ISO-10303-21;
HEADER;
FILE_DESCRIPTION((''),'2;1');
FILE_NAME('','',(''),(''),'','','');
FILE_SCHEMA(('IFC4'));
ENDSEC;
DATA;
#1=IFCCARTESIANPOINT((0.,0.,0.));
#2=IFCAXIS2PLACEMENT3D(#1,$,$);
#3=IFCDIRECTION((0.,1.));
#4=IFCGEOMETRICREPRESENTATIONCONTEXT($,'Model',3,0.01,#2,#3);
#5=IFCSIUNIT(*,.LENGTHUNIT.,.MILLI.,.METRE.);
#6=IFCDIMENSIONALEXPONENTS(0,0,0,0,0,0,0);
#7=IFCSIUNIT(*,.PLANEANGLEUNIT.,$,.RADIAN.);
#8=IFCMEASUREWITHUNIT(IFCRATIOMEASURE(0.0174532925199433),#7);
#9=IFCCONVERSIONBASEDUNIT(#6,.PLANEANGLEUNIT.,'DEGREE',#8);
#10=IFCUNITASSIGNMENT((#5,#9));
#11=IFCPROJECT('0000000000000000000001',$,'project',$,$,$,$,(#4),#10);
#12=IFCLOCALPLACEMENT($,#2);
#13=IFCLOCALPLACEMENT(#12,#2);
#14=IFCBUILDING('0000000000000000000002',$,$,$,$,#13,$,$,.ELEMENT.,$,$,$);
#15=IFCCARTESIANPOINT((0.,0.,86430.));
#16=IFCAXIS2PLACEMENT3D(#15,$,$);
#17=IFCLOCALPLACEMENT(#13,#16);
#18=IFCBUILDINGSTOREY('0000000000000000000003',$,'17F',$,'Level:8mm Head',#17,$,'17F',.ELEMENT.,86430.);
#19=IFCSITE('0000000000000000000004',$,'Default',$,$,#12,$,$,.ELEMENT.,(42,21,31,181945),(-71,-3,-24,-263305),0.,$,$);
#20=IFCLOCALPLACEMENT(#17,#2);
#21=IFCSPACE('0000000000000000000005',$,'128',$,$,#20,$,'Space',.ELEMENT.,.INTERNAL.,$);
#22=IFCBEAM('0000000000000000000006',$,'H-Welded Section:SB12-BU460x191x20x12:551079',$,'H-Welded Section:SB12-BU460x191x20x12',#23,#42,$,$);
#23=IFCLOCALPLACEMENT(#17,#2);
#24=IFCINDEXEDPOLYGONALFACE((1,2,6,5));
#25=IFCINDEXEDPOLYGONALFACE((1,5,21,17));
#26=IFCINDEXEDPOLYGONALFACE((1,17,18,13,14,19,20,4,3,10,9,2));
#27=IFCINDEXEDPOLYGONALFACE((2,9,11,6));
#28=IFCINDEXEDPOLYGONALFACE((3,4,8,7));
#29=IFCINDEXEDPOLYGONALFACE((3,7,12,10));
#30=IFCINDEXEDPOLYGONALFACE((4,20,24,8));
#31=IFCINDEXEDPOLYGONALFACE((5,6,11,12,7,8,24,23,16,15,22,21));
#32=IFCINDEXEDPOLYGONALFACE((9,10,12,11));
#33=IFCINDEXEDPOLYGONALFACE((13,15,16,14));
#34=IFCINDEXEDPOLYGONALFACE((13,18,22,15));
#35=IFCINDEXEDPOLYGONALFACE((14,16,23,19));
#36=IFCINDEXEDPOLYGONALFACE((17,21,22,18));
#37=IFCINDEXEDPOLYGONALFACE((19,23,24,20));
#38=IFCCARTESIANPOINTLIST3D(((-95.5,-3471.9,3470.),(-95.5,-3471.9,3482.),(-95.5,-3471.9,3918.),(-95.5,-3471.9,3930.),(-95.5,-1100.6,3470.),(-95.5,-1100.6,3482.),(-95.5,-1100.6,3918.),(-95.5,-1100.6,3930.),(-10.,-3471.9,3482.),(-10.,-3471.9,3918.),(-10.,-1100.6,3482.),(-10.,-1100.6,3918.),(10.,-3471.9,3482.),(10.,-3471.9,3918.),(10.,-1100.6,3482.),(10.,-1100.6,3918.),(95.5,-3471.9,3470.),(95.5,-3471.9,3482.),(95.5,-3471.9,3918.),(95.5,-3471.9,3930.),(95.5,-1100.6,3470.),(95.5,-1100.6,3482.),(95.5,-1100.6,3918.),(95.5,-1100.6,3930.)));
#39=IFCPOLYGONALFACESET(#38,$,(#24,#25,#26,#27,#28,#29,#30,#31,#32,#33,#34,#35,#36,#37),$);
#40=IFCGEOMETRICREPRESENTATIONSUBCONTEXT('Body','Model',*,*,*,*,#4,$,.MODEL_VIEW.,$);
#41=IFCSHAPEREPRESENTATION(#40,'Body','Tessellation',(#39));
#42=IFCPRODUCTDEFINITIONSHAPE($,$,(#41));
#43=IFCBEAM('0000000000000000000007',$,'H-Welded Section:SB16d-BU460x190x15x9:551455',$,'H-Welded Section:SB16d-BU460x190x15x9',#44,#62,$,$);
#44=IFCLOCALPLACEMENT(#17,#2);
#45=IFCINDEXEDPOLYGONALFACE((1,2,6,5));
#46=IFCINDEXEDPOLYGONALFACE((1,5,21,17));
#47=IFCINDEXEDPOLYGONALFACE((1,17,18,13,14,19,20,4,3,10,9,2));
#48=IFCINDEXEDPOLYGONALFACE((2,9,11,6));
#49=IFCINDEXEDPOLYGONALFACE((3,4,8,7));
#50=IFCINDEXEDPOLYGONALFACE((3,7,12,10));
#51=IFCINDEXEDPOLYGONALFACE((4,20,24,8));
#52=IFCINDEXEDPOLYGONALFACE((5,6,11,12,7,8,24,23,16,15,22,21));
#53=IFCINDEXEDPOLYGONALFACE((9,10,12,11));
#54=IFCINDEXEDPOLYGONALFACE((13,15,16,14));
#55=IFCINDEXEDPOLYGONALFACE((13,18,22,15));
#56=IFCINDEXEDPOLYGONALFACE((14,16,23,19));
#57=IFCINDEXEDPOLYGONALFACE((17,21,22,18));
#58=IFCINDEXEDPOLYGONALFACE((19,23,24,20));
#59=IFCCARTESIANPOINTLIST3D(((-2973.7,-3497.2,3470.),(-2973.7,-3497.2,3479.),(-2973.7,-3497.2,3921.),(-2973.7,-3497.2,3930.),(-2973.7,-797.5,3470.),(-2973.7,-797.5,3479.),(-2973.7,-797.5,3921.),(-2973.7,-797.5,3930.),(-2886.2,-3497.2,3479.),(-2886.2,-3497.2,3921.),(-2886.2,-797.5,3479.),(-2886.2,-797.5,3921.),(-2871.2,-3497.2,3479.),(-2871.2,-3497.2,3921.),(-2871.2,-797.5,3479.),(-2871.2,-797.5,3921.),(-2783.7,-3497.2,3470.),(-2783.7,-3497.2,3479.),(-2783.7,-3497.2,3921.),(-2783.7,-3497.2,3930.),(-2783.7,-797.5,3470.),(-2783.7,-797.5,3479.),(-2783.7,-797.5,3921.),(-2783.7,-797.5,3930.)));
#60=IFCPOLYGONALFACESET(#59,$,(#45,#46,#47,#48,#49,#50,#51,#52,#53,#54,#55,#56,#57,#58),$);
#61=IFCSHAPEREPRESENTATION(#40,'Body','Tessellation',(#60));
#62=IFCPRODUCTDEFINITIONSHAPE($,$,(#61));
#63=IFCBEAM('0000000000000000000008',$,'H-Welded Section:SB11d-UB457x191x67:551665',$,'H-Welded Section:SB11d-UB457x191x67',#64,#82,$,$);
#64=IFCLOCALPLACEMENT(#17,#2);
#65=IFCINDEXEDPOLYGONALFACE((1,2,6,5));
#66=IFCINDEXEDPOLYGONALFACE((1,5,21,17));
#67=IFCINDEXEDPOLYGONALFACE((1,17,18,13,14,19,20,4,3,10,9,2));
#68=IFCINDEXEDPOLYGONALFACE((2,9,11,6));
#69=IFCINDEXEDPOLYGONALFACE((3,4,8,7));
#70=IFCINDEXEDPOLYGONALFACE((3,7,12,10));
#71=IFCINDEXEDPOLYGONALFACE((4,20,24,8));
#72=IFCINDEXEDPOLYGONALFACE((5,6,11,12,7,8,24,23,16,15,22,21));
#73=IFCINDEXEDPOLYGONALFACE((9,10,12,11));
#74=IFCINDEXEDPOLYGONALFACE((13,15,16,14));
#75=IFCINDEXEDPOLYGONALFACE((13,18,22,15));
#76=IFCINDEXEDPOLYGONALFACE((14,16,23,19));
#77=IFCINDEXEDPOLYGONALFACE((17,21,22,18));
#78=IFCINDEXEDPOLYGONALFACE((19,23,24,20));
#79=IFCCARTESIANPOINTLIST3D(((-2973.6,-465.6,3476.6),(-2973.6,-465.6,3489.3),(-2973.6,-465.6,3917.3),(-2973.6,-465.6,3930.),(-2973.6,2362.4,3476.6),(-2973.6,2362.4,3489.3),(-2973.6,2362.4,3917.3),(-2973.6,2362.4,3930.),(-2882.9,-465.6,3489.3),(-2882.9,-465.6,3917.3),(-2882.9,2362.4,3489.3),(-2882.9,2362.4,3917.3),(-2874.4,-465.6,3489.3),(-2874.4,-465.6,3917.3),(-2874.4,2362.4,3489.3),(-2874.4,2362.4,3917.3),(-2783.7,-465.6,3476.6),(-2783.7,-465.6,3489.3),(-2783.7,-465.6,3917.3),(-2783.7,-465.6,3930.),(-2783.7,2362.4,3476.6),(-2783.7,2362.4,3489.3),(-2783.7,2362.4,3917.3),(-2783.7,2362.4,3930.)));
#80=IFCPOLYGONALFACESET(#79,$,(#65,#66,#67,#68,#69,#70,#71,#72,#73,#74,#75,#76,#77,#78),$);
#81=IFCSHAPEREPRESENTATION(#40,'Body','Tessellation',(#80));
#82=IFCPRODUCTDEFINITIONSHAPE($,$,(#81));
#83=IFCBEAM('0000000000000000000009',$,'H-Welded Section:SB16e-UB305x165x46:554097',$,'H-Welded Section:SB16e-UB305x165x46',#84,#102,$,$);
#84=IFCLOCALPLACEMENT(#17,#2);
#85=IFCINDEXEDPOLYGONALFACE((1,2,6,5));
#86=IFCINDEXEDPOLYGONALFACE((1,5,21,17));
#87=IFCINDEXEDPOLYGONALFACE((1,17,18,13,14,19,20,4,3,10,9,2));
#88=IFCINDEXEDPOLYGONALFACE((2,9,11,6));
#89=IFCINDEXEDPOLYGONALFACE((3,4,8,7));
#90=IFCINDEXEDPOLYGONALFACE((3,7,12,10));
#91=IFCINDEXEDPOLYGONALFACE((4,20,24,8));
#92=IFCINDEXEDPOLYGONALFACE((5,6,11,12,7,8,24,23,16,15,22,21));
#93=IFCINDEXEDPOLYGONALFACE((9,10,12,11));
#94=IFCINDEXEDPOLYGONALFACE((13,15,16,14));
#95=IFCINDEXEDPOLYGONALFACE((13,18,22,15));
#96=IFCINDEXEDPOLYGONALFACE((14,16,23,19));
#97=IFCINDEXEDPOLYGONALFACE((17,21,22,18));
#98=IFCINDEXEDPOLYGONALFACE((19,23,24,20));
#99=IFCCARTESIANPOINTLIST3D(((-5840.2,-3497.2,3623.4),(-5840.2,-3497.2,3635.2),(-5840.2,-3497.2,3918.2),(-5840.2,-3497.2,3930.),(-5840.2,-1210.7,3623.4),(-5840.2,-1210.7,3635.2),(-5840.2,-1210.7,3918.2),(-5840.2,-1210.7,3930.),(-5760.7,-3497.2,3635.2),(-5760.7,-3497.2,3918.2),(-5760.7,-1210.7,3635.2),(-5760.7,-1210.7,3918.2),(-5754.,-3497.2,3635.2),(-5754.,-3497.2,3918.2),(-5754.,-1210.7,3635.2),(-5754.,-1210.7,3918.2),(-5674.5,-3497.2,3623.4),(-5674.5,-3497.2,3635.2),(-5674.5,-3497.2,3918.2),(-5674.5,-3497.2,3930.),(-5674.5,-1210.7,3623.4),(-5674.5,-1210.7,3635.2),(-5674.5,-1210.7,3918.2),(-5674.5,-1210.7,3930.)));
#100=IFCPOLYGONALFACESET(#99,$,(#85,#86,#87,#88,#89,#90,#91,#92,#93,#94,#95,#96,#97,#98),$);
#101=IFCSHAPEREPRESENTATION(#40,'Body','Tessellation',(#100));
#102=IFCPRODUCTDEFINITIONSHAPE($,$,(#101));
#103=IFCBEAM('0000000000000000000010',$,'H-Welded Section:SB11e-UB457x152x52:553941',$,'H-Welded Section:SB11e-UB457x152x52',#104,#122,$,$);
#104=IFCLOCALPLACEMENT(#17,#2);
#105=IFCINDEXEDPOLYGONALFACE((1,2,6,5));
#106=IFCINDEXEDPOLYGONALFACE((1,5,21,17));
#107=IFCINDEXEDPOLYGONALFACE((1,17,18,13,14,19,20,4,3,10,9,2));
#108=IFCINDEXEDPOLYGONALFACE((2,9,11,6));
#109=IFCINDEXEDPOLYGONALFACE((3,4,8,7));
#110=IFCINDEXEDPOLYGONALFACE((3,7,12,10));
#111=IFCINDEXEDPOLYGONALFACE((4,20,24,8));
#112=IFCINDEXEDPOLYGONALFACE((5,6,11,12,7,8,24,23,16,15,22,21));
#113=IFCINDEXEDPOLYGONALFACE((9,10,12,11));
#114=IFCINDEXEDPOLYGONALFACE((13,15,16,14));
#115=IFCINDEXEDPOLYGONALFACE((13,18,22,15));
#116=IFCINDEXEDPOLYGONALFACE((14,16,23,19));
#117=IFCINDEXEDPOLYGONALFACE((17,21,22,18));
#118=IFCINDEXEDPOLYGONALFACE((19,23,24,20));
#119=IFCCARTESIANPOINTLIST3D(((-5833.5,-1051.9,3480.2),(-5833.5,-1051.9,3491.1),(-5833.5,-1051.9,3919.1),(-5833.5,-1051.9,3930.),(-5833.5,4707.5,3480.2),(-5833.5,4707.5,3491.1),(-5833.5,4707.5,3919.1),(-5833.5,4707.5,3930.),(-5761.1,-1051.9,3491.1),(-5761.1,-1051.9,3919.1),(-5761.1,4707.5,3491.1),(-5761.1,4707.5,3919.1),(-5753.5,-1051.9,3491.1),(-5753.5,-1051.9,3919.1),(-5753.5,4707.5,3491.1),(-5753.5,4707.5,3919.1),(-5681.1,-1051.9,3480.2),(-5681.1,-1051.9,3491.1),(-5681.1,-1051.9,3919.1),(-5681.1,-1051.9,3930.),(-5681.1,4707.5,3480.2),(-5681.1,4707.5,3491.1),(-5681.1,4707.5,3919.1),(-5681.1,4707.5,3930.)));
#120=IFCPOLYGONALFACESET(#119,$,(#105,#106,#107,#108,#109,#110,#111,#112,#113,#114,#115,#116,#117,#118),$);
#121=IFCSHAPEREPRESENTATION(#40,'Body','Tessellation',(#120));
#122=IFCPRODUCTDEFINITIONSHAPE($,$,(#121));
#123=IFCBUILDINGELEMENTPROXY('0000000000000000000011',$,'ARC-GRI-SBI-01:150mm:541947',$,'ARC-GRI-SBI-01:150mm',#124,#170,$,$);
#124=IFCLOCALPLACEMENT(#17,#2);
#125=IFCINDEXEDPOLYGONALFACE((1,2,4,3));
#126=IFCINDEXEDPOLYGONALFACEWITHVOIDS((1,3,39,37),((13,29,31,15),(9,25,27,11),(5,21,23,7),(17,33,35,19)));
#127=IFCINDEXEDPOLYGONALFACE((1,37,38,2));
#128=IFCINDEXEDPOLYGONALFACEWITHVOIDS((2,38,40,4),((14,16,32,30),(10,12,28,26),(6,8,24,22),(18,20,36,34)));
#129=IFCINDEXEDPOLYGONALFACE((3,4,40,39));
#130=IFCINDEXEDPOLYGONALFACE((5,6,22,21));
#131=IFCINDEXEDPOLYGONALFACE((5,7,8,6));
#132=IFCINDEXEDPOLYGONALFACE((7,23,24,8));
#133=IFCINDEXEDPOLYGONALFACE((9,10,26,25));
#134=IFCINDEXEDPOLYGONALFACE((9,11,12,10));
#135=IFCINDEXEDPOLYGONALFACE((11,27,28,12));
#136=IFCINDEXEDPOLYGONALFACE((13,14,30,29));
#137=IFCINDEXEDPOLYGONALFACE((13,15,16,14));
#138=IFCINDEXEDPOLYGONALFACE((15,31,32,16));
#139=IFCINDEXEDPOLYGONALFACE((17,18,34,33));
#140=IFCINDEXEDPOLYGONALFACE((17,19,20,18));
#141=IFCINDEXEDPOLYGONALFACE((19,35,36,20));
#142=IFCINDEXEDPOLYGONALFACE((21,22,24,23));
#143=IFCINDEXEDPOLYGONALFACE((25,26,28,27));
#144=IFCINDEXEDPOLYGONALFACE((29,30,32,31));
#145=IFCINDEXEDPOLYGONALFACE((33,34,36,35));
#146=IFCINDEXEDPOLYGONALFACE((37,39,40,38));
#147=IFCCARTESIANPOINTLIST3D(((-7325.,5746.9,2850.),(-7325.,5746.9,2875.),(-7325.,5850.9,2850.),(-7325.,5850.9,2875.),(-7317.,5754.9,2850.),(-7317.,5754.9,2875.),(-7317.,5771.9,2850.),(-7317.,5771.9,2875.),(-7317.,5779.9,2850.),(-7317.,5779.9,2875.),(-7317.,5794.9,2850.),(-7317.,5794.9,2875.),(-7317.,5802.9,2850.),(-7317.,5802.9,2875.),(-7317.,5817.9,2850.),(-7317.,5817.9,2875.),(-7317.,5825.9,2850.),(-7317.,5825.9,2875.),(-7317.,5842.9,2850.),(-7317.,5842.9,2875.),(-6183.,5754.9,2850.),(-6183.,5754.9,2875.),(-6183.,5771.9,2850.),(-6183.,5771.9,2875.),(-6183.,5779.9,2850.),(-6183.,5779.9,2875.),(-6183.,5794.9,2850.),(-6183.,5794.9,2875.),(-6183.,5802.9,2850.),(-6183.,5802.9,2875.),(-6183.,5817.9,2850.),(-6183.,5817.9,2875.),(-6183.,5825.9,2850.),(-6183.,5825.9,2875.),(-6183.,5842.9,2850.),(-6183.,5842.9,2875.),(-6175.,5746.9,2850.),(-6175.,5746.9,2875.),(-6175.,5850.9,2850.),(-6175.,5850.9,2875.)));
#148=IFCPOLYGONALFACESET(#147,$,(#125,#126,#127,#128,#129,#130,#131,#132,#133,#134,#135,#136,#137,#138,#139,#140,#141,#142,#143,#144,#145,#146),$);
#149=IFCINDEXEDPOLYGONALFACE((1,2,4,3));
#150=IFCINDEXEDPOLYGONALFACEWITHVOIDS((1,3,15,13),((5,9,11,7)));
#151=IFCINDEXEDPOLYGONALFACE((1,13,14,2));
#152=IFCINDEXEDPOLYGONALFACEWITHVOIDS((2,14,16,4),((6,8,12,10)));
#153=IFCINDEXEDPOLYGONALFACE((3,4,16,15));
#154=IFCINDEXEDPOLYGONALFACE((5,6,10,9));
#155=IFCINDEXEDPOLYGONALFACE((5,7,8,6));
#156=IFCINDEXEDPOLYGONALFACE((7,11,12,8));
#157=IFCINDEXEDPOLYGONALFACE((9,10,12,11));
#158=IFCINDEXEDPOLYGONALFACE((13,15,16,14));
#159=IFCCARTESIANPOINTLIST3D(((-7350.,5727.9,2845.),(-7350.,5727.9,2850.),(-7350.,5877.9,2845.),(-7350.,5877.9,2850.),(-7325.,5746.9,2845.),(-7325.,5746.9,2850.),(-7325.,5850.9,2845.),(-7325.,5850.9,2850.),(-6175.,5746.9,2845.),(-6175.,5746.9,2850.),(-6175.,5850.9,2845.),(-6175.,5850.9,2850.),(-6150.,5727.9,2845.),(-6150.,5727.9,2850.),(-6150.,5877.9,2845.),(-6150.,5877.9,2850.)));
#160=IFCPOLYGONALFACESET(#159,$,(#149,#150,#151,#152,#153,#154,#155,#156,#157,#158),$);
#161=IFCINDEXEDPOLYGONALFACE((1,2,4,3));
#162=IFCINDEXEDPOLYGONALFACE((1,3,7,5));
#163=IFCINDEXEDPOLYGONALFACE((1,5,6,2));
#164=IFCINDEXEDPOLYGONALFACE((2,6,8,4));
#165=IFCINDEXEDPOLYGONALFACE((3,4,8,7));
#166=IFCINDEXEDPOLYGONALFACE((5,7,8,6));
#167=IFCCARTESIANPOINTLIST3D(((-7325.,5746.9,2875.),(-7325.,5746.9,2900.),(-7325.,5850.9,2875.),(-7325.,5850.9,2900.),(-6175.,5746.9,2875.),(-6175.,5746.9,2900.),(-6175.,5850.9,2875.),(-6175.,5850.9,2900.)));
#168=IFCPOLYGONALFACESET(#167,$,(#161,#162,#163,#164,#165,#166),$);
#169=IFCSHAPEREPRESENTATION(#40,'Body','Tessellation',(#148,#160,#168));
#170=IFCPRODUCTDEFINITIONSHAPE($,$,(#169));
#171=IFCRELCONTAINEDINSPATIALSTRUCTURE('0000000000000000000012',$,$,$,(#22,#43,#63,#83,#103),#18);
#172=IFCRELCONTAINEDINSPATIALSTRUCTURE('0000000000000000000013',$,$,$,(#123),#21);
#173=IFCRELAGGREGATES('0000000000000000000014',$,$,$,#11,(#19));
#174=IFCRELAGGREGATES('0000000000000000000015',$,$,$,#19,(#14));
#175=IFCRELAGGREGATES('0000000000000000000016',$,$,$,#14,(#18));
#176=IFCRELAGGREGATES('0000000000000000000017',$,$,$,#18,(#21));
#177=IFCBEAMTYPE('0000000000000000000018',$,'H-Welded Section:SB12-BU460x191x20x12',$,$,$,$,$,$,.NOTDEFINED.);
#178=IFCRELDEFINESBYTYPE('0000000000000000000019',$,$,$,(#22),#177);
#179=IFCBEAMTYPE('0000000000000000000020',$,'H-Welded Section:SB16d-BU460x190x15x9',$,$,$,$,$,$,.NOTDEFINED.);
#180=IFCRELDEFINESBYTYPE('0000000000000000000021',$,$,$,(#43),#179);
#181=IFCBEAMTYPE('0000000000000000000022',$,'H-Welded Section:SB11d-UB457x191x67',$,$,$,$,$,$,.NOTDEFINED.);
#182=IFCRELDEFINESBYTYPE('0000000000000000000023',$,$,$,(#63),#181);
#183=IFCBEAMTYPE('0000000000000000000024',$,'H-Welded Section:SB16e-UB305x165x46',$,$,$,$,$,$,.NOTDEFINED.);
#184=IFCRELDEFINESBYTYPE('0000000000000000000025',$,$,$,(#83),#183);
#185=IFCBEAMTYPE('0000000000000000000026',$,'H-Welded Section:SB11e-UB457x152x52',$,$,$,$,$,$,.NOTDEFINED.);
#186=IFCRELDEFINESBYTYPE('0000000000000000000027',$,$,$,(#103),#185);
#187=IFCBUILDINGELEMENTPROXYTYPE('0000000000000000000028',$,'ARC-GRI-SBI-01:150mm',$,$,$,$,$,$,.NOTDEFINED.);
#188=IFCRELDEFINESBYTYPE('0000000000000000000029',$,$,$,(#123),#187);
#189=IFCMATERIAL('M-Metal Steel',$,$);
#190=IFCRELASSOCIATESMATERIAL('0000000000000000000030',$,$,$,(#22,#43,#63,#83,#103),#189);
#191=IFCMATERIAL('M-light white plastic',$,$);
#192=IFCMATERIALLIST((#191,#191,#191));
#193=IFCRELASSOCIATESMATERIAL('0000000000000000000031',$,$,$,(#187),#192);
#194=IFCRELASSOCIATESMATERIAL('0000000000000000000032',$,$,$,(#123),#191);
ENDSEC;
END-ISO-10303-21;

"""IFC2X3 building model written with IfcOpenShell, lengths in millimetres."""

from ifc_helpers import new_model, entity, si_unit, converted_unit, direction, frame, frame_2d, origin, origin_2d_with_axis, place, context, subcontext, project, spatial, polyline, rectangle, i_section, outline, extrude, source, transform, mapped, material, material_list, type_object, type_shapes, element, save


model = new_model("IFC2X3")

# Units and contexts
model_context = context("Model", 3, precision=0.01, world=origin(), true_north=direction((0.0, 1.0)))
body_context = subcontext(model_context, "Body", "Model", "MODEL_VIEW")
ifc_project = project(units=[si_unit("LENGTHUNIT", "METRE", prefix="MILLI"), converted_unit("PLANEANGLEUNIT", "DEGREE", entity("IfcRatioMeasure", 0.0174532925199433), si_unit("PLANEANGLEUNIT", "RADIAN"), dimensions=[0, 0, 0, 0, 0, 0, 0])], contexts=[model_context])

# Site, building, storey
site_placement = place(None, origin())
site = spatial("IfcSite", under=ifc_project, at=site_placement, Name="Default", CompositionType="ELEMENT", RefLatitude=(42, 21, 31, 181945), RefLongitude=(-71, -3, -24, -263305), RefElevation=0.0)
building_placement = place(site_placement, origin())
building = spatial("IfcBuilding", under=site, at=building_placement, CompositionType="ELEMENT")
storey_placement = place(building_placement, frame((0.0, 0.0, 86430.0)))
storey = spatial("IfcBuildingStorey", under=building, at=storey_placement, Name="17F", ObjectType="Level:8mm Head", LongName="17F", CompositionType="ELEMENT", Elevation=86430.0)

# Beams
ifc_material_1 = material(Name="M-Metal Steel")
beam_type_1 = type_object("IfcBeamType", Name="H-Welded Section:SB12-BU460x191x20x12", PredefinedType="NOTDEFINED")
beam_1_placement = place(storey_placement, frame((0.0, -667.1, 0.0), z_axis=(0.0, 0.0, 1.0), x_axis=(0.0, -1.0, 0.0)))
element("IfcBeam", 1, at=beam_1_placement, inside=storey, type_object=beam_type_1, material=ifc_material_1, Name="H-Welded Section:SB12-BU460x191x20x12:551079", ObjectType="H-Welded Section:SB12-BU460x191x20x12", context=body_context, shape_type="SweptSolid", body=[
    extrude(i_section(OverallWidth=191.0, OverallDepth=460.0, WebThickness=20.0, FlangeThickness=12.0, at=frame_2d((0.0, 0.0), x_axis=(0.0, 1.0))), frame((433.5, 0.0, 3700.0), z_axis=(1.0, 0.0, 0.0), x_axis=(0.0, 0.0, -1.0)), (0.0, 0.0, 1.0), 2371.3),
])
beam_type_2 = type_object("IfcBeamType", Name="H-Welded Section:SB16d-BU460x190x15x9", PredefinedType="NOTDEFINED")
beam_2_placement = place(storey_placement, frame((-2878.7, -4004.7, 0.0), z_axis=(0.0, 0.0, 1.0), x_axis=(0.0, 1.0, 0.0)))
element("IfcBeam", 2, at=beam_2_placement, inside=storey, type_object=beam_type_2, material=ifc_material_1, Name="H-Welded Section:SB16d-BU460x190x15x9:551455", ObjectType="H-Welded Section:SB16d-BU460x190x15x9", context=body_context, shape_type="SweptSolid", body=[
    extrude(i_section(OverallWidth=190.0, OverallDepth=460.0, WebThickness=15.0, FlangeThickness=9.0, at=frame_2d((0.0, 0.0), x_axis=(0.0, 1.0))), frame((507.5, 0.0, 3700.0), z_axis=(1.0, 0.0, 0.0), x_axis=(0.0, 0.0, -1.0)), (0.0, 0.0, 1.0), 2699.7),
])
beam_type_3 = type_object("IfcBeamType", Name="H-Welded Section:SB11d-UB457x191x67", PredefinedType="NOTDEFINED")
beam_3_placement = place(storey_placement, frame((-2878.7, 2476.3, 0.0), z_axis=(0.0, 0.0, 1.0), x_axis=(0.0, -1.0, 0.0)))
element("IfcBeam", 3, at=beam_3_placement, inside=storey, type_object=beam_type_3, material=ifc_material_1, Name="H-Welded Section:SB11d-UB457x191x67:551665", ObjectType="H-Welded Section:SB11d-UB457x191x67", context=body_context, shape_type="SweptSolid", body=[
    extrude(i_section(OverallWidth=189.9, OverallDepth=453.4, WebThickness=8.5, FlangeThickness=12.7, at=frame_2d((0.0, 0.0), x_axis=(0.0, 1.0))), frame((113.9, 0.0, 3703.3), z_axis=(1.0, 0.0, 0.0), x_axis=(0.0, 0.0, -1.0)), (0.0, 0.0, 1.0), 2828.0),
])
beam_type_4 = type_object("IfcBeamType", Name="H-Welded Section:SB16e-UB305x165x46", PredefinedType="NOTDEFINED")
beam_4_placement = place(storey_placement, frame((-5757.3, -3505.2, 0.0), z_axis=(0.0, 0.0, 1.0), x_axis=(0.0, 1.0, 0.0)))
element("IfcBeam", 4, at=beam_4_placement, inside=storey, type_object=beam_type_4, material=ifc_material_1, Name="H-Welded Section:SB16e-UB305x165x46:554097", ObjectType="H-Welded Section:SB16e-UB305x165x46", context=body_context, shape_type="SweptSolid", body=[
    extrude(i_section(OverallWidth=165.7, OverallDepth=306.6, WebThickness=6.7, FlangeThickness=11.8, at=frame_2d((0.0, 0.0), x_axis=(0.0, 1.0))), frame((8.0, 0.0, 3776.7), z_axis=(1.0, 0.0, 0.0), x_axis=(0.0, 0.0, -1.0)), (0.0, 0.0, 1.0), 2286.5),
])
beam_type_5 = type_object("IfcBeamType", Name="H-Welded Section:SB11e-UB457x152x52", PredefinedType="NOTDEFINED")
beam_5_placement = place(storey_placement, frame((-5757.3, -1083.7, 0.0), z_axis=(0.0, 0.0, 1.0), x_axis=(0.0, 1.0, 0.0)))
element("IfcBeam", 5, at=beam_5_placement, inside=storey, type_object=beam_type_5, material=ifc_material_1, Name="H-Welded Section:SB11e-UB457x152x52:553941", ObjectType="H-Welded Section:SB11e-UB457x152x52", context=body_context, shape_type="SweptSolid", body=[
    extrude(i_section(OverallWidth=152.4, OverallDepth=449.8, WebThickness=7.6, FlangeThickness=10.9, at=frame_2d((0.0, 0.0), x_axis=(0.0, 1.0))), frame((31.8, 0.0, 3705.1), z_axis=(1.0, 0.0, 0.0), x_axis=(0.0, 0.0, -1.0)), (0.0, 0.0, 1.0), 5759.4),
])

# Shared definitions
space_placement = place(storey_placement, origin())
space = spatial("IfcSpace", under=storey, at=space_placement, Name="128", LongName="Space", CompositionType="ELEMENT", InteriorOrExteriorSpace="INTERNAL")

# Building element proxy
ifc_material_2 = material(Name="M-light white plastic")
ifc_material_list = material_list([ifc_material_2, ifc_material_2, ifc_material_2])
building_element_proxy_type = type_object("IfcBuildingElementProxyType", Name="ARC-GRI-SBI-01:150mm", PredefinedType="NOTDEFINED", material=ifc_material_list)
shared_shape = source(origin(), body_context, "Body", "SweptSolid", [
    extrude(outline(polyline([(-575.0, -52.0), (575.0, -52.0), (575.0, 52.0), (-575.0, 52.0), (-575.0, -52.0)]), holes=[polyline([(-567.0, -44.0), (-567.0, -27.0), (567.0, -27.0), (567.0, -44.0), (-567.0, -44.0)]), polyline([(567.0, -4.0), (567.0, -19.0), (-567.0, -19.0), (-567.0, -4.0), (567.0, -4.0)]), polyline([(-567.0, 44.0), (567.0, 44.0), (567.0, 27.0), (-567.0, 27.0), (-567.0, 44.0)]), polyline([(567.0, 4.0), (-567.0, 4.0), (-567.0, 19.0), (567.0, 19.0), (567.0, 4.0)])]), frame((425.0, 4.0, 4000.0), z_axis=(0.0, 0.0, 1.0), x_axis=(-1.0, 0.0, 0.0)), (0.0, 0.0, 1.0), 25.0),
    extrude(outline(polyline([(-600.0, -75.0), (600.0, -75.0), (600.0, 75.0), (-600.0, 75.0), (-600.0, -75.0)]), holes=[polyline([(-575.0, -56.0), (-575.0, 48.0), (575.0, 48.0), (575.0, -56.0), (-575.0, -56.0)])]), frame((425.0, 0.0, 3995.0), z_axis=(0.0, 0.0, 1.0), x_axis=(-1.0, 0.0, 0.0)), (0.0, 0.0, 1.0), 5.0),
    extrude(rectangle(XDim=1150.0, YDim=104.0, at=origin_2d_with_axis()), frame((425.0, 4.0, 4025.0), z_axis=(0.0, 0.0, 1.0), x_axis=(-1.0, 0.0, 0.0)), (0.0, 0.0, 1.0), 25.0),
])
type_shapes(building_element_proxy_type, [shared_shape])
for number, where, z_axis, x_axis, name in (
    (6, (-6325.0, 5802.9, -1150.0), (0.0, 0.0, 1.0), (-1.0, 0.0, 0.0), "ARC-GRI-SBI-01:150mm:541947"),
):
    element("IfcBuildingElementProxy", number, at=place(space_placement, frame(where, z_axis=z_axis, x_axis=x_axis)), inside=space, type_object=building_element_proxy_type, material=ifc_material_2, Name=name, ObjectType="ARC-GRI-SBI-01:150mm", context=body_context, shape_type="MappedRepresentation", body=[
        mapped(shared_shape, transform((0.0, 0.0, 0.0), scale=1.0)),
    ])

save(model, "model.ifc")
